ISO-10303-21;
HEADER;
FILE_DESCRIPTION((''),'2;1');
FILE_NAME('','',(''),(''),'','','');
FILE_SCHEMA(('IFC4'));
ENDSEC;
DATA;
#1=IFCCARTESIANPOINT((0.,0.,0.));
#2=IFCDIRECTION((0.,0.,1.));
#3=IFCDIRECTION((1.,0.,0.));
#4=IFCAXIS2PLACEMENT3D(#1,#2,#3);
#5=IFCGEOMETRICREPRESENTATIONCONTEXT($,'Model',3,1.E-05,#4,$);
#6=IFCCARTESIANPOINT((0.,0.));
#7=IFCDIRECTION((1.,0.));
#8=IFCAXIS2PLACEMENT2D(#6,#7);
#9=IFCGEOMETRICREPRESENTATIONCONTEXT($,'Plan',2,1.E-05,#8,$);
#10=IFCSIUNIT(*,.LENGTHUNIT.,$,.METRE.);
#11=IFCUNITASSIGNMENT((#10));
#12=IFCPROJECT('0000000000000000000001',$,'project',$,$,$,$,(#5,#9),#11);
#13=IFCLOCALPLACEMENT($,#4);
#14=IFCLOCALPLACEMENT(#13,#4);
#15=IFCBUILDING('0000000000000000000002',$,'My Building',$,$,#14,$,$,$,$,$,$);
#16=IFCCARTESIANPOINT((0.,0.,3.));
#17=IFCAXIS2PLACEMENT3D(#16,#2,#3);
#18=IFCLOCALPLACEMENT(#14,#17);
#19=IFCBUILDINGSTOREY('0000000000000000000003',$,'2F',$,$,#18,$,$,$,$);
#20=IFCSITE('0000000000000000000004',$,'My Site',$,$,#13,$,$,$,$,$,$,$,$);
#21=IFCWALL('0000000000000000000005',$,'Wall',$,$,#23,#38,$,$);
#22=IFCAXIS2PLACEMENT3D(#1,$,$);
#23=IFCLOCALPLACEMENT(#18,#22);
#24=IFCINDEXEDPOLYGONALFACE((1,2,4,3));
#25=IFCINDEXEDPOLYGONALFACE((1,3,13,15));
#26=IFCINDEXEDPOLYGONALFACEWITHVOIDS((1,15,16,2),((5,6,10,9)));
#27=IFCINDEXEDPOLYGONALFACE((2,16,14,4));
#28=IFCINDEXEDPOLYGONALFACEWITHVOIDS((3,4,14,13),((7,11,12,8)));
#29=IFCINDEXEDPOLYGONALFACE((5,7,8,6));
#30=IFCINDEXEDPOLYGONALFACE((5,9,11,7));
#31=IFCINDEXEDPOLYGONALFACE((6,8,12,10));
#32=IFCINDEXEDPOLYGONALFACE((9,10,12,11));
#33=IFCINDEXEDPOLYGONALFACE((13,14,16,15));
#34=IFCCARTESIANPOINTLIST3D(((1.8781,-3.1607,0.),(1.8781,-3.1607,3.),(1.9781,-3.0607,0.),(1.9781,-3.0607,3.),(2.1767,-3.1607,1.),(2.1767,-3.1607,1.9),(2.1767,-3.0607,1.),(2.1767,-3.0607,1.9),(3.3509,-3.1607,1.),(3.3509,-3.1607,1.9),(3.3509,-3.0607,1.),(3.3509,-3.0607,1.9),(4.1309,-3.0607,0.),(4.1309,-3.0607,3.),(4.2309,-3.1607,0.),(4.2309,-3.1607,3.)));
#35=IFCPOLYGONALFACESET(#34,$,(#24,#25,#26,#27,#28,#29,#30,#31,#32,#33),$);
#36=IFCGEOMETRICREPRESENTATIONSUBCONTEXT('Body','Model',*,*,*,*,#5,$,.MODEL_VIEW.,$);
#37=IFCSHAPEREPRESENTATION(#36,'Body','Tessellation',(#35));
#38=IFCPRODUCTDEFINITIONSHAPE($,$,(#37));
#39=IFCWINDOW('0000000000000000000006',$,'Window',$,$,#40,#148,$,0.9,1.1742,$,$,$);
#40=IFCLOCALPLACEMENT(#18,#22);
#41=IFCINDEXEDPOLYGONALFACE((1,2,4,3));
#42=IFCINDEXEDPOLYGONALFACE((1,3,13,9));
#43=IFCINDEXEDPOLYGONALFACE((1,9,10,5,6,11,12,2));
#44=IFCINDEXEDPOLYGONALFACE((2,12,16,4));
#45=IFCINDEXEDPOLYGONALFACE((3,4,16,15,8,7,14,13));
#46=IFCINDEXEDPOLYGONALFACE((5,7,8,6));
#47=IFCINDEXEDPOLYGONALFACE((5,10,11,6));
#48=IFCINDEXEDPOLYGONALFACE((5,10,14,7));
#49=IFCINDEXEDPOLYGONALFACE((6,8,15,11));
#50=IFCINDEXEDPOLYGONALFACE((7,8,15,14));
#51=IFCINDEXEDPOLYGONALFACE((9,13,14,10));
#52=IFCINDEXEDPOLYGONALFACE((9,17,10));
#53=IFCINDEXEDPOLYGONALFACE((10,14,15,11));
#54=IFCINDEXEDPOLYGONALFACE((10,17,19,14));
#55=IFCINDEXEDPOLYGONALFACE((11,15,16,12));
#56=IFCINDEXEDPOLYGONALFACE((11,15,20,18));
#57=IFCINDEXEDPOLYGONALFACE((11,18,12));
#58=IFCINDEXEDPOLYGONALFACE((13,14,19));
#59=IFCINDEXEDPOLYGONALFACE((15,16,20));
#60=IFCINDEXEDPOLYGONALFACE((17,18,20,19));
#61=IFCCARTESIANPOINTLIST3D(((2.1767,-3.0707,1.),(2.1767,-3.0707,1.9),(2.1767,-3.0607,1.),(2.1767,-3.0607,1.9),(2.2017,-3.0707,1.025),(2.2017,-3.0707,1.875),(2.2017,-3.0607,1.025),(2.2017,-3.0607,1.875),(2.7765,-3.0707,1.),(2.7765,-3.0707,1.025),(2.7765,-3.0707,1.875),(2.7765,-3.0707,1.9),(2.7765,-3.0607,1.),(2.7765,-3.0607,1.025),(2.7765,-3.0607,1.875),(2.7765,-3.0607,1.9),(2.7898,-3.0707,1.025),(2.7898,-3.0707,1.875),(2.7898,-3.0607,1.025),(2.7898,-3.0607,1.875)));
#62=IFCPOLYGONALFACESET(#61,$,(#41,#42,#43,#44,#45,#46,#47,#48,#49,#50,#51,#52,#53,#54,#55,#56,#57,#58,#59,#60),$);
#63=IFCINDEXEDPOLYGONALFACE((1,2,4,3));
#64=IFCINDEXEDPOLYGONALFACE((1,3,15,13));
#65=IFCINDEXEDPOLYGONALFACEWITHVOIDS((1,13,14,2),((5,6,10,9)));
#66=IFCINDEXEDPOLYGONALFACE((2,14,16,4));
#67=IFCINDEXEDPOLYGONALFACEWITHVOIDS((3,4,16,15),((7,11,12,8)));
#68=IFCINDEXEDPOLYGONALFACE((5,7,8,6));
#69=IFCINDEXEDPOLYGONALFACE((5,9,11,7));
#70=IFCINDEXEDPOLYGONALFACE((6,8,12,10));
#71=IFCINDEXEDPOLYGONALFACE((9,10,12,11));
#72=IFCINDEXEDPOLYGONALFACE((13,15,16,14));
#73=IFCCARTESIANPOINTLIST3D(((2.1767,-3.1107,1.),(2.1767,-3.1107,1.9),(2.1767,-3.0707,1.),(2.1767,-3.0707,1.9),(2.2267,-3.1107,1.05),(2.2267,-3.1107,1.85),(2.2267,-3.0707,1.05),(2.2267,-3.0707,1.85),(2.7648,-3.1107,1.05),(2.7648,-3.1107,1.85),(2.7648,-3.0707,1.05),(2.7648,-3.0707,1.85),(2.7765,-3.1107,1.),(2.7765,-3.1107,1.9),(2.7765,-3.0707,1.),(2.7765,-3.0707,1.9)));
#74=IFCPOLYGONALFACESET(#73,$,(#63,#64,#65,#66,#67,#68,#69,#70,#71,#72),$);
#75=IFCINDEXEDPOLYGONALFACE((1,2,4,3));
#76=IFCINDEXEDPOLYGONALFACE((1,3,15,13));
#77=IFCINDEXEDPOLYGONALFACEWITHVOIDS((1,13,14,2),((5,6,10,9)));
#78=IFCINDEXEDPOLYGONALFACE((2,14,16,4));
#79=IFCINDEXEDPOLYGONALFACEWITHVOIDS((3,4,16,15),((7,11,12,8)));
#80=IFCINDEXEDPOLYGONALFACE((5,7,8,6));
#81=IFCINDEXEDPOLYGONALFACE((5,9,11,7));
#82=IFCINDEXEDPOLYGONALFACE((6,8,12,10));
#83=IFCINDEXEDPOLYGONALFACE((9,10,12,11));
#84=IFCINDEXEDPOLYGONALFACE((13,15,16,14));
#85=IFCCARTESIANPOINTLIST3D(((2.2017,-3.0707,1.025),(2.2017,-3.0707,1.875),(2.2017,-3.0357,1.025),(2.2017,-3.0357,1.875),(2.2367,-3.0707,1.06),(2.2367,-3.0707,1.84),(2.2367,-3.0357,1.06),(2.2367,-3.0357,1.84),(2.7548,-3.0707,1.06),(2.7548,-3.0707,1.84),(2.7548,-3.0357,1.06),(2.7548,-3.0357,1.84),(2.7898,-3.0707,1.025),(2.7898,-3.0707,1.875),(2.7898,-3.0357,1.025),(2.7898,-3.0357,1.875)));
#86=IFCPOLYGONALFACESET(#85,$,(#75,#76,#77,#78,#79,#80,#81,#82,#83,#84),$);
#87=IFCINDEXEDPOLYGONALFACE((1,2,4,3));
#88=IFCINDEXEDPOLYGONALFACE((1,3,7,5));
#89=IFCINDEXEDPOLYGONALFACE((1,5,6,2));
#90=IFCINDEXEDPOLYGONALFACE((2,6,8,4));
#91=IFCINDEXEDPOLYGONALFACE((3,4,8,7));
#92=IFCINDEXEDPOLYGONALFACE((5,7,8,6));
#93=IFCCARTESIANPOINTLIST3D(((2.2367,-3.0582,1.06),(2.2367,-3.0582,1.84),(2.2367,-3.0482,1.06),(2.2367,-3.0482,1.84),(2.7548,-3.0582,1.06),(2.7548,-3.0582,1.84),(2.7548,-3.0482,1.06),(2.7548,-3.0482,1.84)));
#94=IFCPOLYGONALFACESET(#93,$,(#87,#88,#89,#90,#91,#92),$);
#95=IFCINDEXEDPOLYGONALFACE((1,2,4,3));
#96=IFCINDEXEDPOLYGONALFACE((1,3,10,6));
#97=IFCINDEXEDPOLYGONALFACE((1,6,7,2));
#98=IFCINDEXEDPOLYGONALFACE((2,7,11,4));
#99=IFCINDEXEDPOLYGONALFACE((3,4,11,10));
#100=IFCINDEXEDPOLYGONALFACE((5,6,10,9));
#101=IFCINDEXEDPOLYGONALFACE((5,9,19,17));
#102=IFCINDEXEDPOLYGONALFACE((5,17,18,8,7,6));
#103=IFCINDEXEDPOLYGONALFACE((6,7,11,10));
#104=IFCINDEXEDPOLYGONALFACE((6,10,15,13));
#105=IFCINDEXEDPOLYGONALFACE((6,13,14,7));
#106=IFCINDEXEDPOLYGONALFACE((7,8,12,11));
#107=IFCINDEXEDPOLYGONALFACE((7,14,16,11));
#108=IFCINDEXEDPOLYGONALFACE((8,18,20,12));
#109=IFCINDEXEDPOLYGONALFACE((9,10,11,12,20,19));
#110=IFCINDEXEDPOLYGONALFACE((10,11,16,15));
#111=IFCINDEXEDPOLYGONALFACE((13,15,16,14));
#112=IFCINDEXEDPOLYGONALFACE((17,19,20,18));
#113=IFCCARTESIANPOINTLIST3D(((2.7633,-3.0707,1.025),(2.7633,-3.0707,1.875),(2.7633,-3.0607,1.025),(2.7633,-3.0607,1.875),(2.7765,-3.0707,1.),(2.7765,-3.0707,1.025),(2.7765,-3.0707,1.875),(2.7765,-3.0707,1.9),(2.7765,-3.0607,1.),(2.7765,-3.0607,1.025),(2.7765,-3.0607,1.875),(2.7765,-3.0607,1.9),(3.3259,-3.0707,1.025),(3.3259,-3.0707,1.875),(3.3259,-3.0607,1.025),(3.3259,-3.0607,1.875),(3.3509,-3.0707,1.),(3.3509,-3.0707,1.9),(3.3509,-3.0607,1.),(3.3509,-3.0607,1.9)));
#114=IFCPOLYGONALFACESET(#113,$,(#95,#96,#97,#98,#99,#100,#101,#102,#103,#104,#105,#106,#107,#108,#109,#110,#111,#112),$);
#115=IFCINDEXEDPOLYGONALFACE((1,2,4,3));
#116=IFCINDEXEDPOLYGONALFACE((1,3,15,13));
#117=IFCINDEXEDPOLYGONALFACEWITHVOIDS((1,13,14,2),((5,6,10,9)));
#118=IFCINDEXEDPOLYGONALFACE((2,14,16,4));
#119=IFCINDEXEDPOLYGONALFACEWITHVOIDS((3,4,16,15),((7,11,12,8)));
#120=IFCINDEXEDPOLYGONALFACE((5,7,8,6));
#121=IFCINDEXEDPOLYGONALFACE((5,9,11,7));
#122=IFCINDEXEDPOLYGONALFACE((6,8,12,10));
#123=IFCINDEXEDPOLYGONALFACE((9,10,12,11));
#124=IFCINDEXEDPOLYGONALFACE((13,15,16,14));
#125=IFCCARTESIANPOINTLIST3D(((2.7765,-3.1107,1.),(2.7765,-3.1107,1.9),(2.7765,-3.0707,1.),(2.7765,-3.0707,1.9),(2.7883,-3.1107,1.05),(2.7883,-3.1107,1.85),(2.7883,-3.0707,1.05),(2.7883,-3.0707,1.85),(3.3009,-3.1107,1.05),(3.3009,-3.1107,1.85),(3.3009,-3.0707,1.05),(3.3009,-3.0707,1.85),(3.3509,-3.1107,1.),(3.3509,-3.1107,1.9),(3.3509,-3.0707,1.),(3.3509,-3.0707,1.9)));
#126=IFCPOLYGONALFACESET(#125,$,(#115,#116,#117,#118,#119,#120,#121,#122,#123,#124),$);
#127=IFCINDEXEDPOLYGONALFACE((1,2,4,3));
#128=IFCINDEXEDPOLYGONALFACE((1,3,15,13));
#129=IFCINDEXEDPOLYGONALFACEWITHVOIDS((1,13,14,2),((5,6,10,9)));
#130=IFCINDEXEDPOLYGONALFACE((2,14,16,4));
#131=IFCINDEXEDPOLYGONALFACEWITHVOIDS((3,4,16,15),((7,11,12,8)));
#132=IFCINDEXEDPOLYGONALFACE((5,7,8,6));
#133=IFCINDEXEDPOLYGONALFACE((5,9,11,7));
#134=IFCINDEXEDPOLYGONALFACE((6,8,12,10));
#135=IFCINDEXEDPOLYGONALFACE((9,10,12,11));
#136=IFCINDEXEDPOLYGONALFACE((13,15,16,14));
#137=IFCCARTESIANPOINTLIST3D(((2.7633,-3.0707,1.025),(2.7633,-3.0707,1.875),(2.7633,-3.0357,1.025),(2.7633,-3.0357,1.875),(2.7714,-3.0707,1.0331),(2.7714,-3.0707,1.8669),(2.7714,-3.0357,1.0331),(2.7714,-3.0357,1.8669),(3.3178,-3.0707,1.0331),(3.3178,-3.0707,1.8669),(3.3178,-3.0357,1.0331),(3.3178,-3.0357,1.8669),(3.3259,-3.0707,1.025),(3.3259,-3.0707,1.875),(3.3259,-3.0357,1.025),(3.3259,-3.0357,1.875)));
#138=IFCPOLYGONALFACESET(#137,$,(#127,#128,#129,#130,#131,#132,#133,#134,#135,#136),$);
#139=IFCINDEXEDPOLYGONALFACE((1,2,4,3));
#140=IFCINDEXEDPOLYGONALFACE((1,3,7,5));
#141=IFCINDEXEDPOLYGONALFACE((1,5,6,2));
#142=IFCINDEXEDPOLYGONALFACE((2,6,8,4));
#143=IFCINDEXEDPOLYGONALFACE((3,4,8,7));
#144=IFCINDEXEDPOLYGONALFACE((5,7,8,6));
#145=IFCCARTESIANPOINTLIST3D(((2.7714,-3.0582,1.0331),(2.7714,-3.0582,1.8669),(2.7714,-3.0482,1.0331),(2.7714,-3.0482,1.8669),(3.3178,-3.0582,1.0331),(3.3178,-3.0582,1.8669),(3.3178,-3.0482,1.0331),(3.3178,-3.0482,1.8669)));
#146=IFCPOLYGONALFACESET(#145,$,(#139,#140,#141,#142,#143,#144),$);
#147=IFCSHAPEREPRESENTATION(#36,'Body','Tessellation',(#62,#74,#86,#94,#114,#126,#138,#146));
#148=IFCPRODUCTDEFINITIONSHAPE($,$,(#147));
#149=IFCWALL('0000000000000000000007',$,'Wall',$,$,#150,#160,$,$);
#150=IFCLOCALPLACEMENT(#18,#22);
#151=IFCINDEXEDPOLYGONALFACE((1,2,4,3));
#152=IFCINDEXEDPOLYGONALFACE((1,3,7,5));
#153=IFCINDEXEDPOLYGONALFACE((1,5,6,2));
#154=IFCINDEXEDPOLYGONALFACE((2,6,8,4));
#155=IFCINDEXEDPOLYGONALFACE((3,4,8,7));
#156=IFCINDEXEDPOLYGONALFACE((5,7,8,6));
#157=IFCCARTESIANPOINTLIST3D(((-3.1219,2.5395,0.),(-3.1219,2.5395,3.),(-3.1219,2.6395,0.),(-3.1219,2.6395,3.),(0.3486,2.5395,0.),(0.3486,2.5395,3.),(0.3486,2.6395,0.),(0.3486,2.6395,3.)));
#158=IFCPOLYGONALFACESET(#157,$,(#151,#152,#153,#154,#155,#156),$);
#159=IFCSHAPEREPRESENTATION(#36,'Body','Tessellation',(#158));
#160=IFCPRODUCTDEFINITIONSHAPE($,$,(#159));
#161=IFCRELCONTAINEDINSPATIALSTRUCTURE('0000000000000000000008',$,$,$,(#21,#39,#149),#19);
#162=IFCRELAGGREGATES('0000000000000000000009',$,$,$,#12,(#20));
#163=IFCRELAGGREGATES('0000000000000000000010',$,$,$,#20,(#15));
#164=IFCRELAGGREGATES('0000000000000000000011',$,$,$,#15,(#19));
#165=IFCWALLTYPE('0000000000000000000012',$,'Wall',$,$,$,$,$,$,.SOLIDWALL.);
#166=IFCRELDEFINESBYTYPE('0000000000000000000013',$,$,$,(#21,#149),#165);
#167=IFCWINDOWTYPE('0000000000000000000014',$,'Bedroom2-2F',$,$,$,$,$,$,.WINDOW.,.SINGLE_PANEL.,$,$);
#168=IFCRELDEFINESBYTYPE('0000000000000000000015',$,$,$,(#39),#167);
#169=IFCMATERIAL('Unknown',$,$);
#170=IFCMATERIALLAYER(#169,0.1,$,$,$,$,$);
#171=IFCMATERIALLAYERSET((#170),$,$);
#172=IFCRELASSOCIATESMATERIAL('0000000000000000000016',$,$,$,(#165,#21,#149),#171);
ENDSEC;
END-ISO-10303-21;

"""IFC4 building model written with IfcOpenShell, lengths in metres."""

from ifc_helpers import new_model, entity, si_unit, frame, origin_with_axes, origin_2d_with_axis, place, context, subcontext, project, spatial, line, indexed_curve, outline, extrude, shape, source, transform, mapped, material, layer, layer_set, layer_usage, type_object, type_shapes, element, fill, save


model = new_model("IFC4")

# Units and contexts
model_context = context("Model", 3, precision=1e-05, world=origin_with_axes())
plan_context = context("Plan", 2, precision=1e-05, world=origin_2d_with_axis())
body_context_1 = subcontext(model_context, "Body", "Model", "MODEL_VIEW")
body_context_2 = subcontext(plan_context, "Body", "Plan", "PLAN_VIEW")
ifc_project = project(units=[si_unit("LENGTHUNIT", "METRE")], contexts=[model_context, plan_context])

# Site, building, storey
site_placement = place(None, origin_with_axes())
site = spatial("IfcSite", under=ifc_project, at=site_placement, Name="My Site")
building_placement = place(site_placement, origin_with_axes())
building = spatial("IfcBuilding", under=site, at=building_placement, Name="My Building")
storey_placement = place(building_placement, frame((0.0, 0.0, 3.0), z_axis=(0.0, 0.0, 1.0), x_axis=(1.0, 0.0, 0.0)))
storey = spatial("IfcBuildingStorey", under=building, at=storey_placement, Name="2F")

# Shared definitions
ifc_material = material(Name="Unknown")

# Shared definitions
ifc_layer_1 = layer(ifc_material, 0.1)
ifc_layer_set_1 = layer_set([ifc_layer_1])
wall_type = type_object("IfcWallType", Name="Wall", PredefinedType="SOLIDWALL", material=ifc_layer_set_1)

# Wall, opening, window
ifc_layer_usage_1 = layer_usage(ifc_layer_set_1, "AXIS2", "POSITIVE", 0.0)
wall_1_placement = place(storey_placement, frame((1.8781, -3.1607, 0.0), z_axis=(0.0, 0.0, 1.0), x_axis=(1.0, 0.0, 0.0)))
wall_1 = element("IfcWall", 1, at=wall_1_placement, inside=storey, type_object=wall_type, material=ifc_layer_usage_1, Name="Wall", context=body_context_1, shape_type="SweptSolid", body=[
    extrude(outline(indexed_curve([(0.0, 0.0), (0.1, 0.1), (2.2528, 0.1), (2.3528, 0.0)], segments=[line(1, 2, 3, 4, 1)])), origin_with_axes(), (0.0, 0.0, 1.0), 3.0),
])
shared_shape_1 = source(origin_with_axes(), body_context_1, "Body", "SweptSolid", [
    extrude(outline(indexed_curve([(0.0, 0.0), (1.1742, 0.0), (1.1742, 0.9), (0.0, 0.9)], segments=[line(1, 2, 3, 4, 1)])), frame((0.0, -0.6, 0.0), z_axis=(0.0, -1.0, 0.0), x_axis=(1.0, 0.0, 0.0)), (0.0, 0.0, -1.0), 1.2),
])
opening_1_placement = place(wall_1_placement, frame((0.2985, 0.0, 1.0), z_axis=(0.0, 0.0, 1.0), x_axis=(1.0, 0.0, 0.0)))
opening_1 = element("IfcOpeningElement", 2, at=opening_1_placement, cuts=wall_1, PredefinedType="OPENING", context=body_context_1, shape_type="MappedRepresentation", body=[
    mapped(shared_shape_1, transform((0.0, 0.0, 0.0), x_axis=(1.0, 0.0, 0.0), y_axis=(0.0, 1.0, 0.0), z_axis=(0.0, 0.0, 1.0), scale=1.0)),
])
window_type = type_object("IfcWindowType", Name="Bedroom2-2F", PartitioningType="SINGLE_PANEL", PredefinedType="WINDOW")
shared_shape_2 = source(origin_with_axes(), body_context_1, "Body", "SweptSolid", [
    extrude(outline(indexed_curve([(0.0, 0.0), (0.5999, 0.0), (0.5999, 0.9), (0.0, 0.9)], segments=[line(1, 2, 3, 4, 1)]), holes=[indexed_curve([(0.025, 0.025), (0.6131, 0.025), (0.6131, 0.875), (0.025, 0.875)], segments=[line(1, 2, 3, 4, 1)])]), frame((0.0, 0.09, 0.0), z_axis=(0.0, -1.0, 0.0), x_axis=(1.0, 0.0, 0.0)), (0.0, 0.0, -1.0), 0.01),
    extrude(outline(indexed_curve([(0.0, 0.0), (0.5999, 0.0), (0.5999, 0.9), (0.0, 0.9)], segments=[line(1, 2, 3, 4, 1)]), holes=[indexed_curve([(0.05, 0.05), (0.5881, 0.05), (0.5881, 0.85), (0.05, 0.85)], segments=[line(1, 2, 3, 4, 1)])]), frame((0.0, 0.05, 0.0), z_axis=(0.0, -1.0, 0.0), x_axis=(1.0, 0.0, 0.0)), (0.0, 0.0, -1.0), 0.04),
    extrude(outline(indexed_curve([(0.0, 0.0), (0.5881, 0.0), (0.5881, 0.85), (0.0, 0.85)], segments=[line(1, 2, 3, 4, 1)]), holes=[indexed_curve([(0.035, 0.035), (0.5531, 0.035), (0.5531, 0.815), (0.035, 0.815)], segments=[line(1, 2, 3, 4, 1)])]), frame((0.025, 0.09, 0.025), z_axis=(0.0, -1.0, 0.0), x_axis=(1.0, 0.0, 0.0)), (0.0, 0.0, -1.0), 0.035),
    extrude(outline(indexed_curve([(0.035, 0.035), (0.5531, 0.035), (0.5531, 0.815), (0.035, 0.815)], segments=[line(1, 2, 3, 4, 1)])), frame((0.025, 0.1025, 0.025), z_axis=(0.0, -1.0, 0.0), x_axis=(1.0, 0.0, 0.0)), (0.0, 0.0, -1.0), 0.01),
    extrude(outline(indexed_curve([(0.0, 0.0), (0.5744, 0.0), (0.5744, 0.9), (0.0, 0.9)], segments=[line(1, 2, 3, 4, 1)]), holes=[indexed_curve([(-0.0132, 0.025), (0.5494, 0.025), (0.5494, 0.875), (-0.0132, 0.875)], segments=[line(1, 2, 3, 4, 1)])]), frame((0.5999, 0.09, 0.0), z_axis=(0.0, -1.0, 0.0), x_axis=(1.0, 0.0, 0.0)), (0.0, 0.0, -1.0), 0.01),
    extrude(outline(indexed_curve([(0.0, 0.0), (0.5744, 0.0), (0.5744, 0.9), (0.0, 0.9)], segments=[line(1, 2, 3, 4, 1)]), holes=[indexed_curve([(0.0118, 0.05), (0.5244, 0.05), (0.5244, 0.85), (0.0118, 0.85)], segments=[line(1, 2, 3, 4, 1)])]), frame((0.5999, 0.05, 0.0), z_axis=(0.0, -1.0, 0.0), x_axis=(1.0, 0.0, 0.0)), (0.0, 0.0, -1.0), 0.04),
    extrude(outline(indexed_curve([(0.0, 0.0), (0.5626, 0.0), (0.5626, 0.85), (0.0, 0.85)], segments=[line(1, 2, 3, 4, 1)]), holes=[indexed_curve([(0.0081, 0.0081), (0.5545, 0.0081), (0.5545, 0.8419), (0.0081, 0.8419)], segments=[line(1, 2, 3, 4, 1)])]), frame((0.5866, 0.09, 0.025), z_axis=(0.0, -1.0, 0.0), x_axis=(1.0, 0.0, 0.0)), (0.0, 0.0, -1.0), 0.035),
    extrude(outline(indexed_curve([(0.0081, 0.0081), (0.5545, 0.0081), (0.5545, 0.8419), (0.0081, 0.8419)], segments=[line(1, 2, 3, 4, 1)])), frame((0.5866, 0.1025, 0.025), z_axis=(0.0, -1.0, 0.0), x_axis=(1.0, 0.0, 0.0)), (0.0, 0.0, -1.0), 0.01),
])
shared_shape_3 = source(origin_with_axes(), body_context_2, "Body", "Curve2D", [
    entity("IfcIndexedPolyCurve", entity("IfcCartesianPointList2D", [[0.05, 0.05], [0.5881, 0.05]])),
    entity("IfcIndexedPolyCurve", entity("IfcCartesianPointList2D", [[0.0, 0.1], [0.025, 0.1], [0.025, 0.09], [0.05, 0.09], [0.05, 0.05], [0.0, 0.05]]), [entity("IfcLineIndex", [1, 2, 3, 4, 5, 6, 1])]),
    entity("IfcIndexedPolyCurve", entity("IfcCartesianPointList2D", [[0.5999, 0.1], [0.6131, 0.1], [0.6131, 0.09], [0.5881, 0.09], [0.5881, 0.05], [0.5999, 0.05]])),
    entity("IfcIndexedPolyCurve", entity("IfcCartesianPointList2D", [[0.025, 0.09], [0.06, 0.09], [0.06, 0.125], [0.025, 0.125]]), [entity("IfcLineIndex", [1, 2, 3, 4, 1])]),
    entity("IfcIndexedPolyCurve", entity("IfcCartesianPointList2D", [[0.6131, 0.09], [0.5781, 0.09], [0.5781, 0.125], [0.6131, 0.125]]), [entity("IfcLineIndex", [1, 2, 3, 4, 1])]),
    entity("IfcIndexedPolyCurve", entity("IfcCartesianPointList2D", [[0.06, 0.09], [0.5781, 0.09]])),
    entity("IfcIndexedPolyCurve", entity("IfcCartesianPointList2D", [[0.06, 0.125], [0.5781, 0.125]])),
    entity("IfcIndexedPolyCurve", entity("IfcCartesianPointList2D", [[0.06, 0.1075], [0.5781, 0.1075]])),
    entity("IfcIndexedPolyCurve", entity("IfcCartesianPointList2D", [[0.6116, 0.05], [1.1242, 0.05]])),
    entity("IfcIndexedPolyCurve", entity("IfcCartesianPointList2D", [[0.5999, 0.1], [0.5866, 0.1], [0.5866, 0.09], [0.6116, 0.09], [0.6116, 0.05], [0.5999, 0.05]])),
    entity("IfcIndexedPolyCurve", entity("IfcCartesianPointList2D", [[1.1742, 0.1], [1.1492, 0.1], [1.1492, 0.09], [1.1242, 0.09], [1.1242, 0.05], [1.1742, 0.05]]), [entity("IfcLineIndex", [1, 2, 3, 4, 5, 6, 1])]),
    entity("IfcIndexedPolyCurve", entity("IfcCartesianPointList2D", [[0.5866, 0.09], [0.5947, 0.09], [0.5947, 0.125], [0.5866, 0.125]]), [entity("IfcLineIndex", [1, 2, 3, 4, 1])]),
    entity("IfcIndexedPolyCurve", entity("IfcCartesianPointList2D", [[1.1492, 0.09], [1.1412, 0.09], [1.1412, 0.125], [1.1492, 0.125]]), [entity("IfcLineIndex", [1, 2, 3, 4, 1])]),
    entity("IfcIndexedPolyCurve", entity("IfcCartesianPointList2D", [[0.5947, 0.09], [1.1412, 0.09]])),
    entity("IfcIndexedPolyCurve", entity("IfcCartesianPointList2D", [[0.5947, 0.125], [1.1412, 0.125]])),
    entity("IfcIndexedPolyCurve", entity("IfcCartesianPointList2D", [[0.5947, 0.1075], [1.1412, 0.1075]])),
])
type_shapes(window_type, [shared_shape_2, shared_shape_3])
window_placement = place(opening_1_placement, frame((0.0, 0.0, 0.0), z_axis=(0.0, 0.0, 1.0), x_axis=(1.0, 0.0, 0.0)))
window = element("IfcWindow", 3, at=window_placement, inside=storey, type_object=window_type, Name="Window", OverallHeight=0.9, OverallWidth=1.1742, shapes=[
    shape(body_context_1, "Body", "MappedRepresentation", [mapped(shared_shape_2, transform((0.0, 0.0, 0.0), x_axis=(1.0, 0.0, 0.0), y_axis=(0.0, 1.0, 0.0), z_axis=(0.0, 0.0, 1.0), scale=1.0))]),
    shape(body_context_2, "Body", "MappedRepresentation", [mapped(shared_shape_3, transform((0.0, 0.0, 0.0), x_axis=(1.0, 0.0, 0.0), y_axis=(0.0, 1.0, 0.0), z_axis=(0.0, 0.0, 1.0), scale=1.0))]),
])
fill(opening_1, window)

# Wall
ifc_layer_usage_2 = layer_usage(ifc_layer_set_1, "AXIS2", "POSITIVE", 0.0)
wall_2_placement = place(storey_placement, frame((0.3486, 2.6395, 0.0), z_axis=(0.0, 0.0, 1.0), x_axis=(-1.0, 0.0, 0.0)))
element("IfcWall", 4, at=wall_2_placement, inside=storey, type_object=wall_type, material=ifc_layer_usage_2, Name="Wall", context=body_context_1, shape_type="SweptSolid", body=[
    extrude(outline(indexed_curve([(0.0, 0.0), (0.0, 0.1), (3.4705, 0.1), (3.4705, 0.0)], segments=[line(1, 2, 3, 4, 1)])), origin_with_axes(), (0.0, 0.0, 1.0), 3.0),
])

save(model, "model.ifc")
